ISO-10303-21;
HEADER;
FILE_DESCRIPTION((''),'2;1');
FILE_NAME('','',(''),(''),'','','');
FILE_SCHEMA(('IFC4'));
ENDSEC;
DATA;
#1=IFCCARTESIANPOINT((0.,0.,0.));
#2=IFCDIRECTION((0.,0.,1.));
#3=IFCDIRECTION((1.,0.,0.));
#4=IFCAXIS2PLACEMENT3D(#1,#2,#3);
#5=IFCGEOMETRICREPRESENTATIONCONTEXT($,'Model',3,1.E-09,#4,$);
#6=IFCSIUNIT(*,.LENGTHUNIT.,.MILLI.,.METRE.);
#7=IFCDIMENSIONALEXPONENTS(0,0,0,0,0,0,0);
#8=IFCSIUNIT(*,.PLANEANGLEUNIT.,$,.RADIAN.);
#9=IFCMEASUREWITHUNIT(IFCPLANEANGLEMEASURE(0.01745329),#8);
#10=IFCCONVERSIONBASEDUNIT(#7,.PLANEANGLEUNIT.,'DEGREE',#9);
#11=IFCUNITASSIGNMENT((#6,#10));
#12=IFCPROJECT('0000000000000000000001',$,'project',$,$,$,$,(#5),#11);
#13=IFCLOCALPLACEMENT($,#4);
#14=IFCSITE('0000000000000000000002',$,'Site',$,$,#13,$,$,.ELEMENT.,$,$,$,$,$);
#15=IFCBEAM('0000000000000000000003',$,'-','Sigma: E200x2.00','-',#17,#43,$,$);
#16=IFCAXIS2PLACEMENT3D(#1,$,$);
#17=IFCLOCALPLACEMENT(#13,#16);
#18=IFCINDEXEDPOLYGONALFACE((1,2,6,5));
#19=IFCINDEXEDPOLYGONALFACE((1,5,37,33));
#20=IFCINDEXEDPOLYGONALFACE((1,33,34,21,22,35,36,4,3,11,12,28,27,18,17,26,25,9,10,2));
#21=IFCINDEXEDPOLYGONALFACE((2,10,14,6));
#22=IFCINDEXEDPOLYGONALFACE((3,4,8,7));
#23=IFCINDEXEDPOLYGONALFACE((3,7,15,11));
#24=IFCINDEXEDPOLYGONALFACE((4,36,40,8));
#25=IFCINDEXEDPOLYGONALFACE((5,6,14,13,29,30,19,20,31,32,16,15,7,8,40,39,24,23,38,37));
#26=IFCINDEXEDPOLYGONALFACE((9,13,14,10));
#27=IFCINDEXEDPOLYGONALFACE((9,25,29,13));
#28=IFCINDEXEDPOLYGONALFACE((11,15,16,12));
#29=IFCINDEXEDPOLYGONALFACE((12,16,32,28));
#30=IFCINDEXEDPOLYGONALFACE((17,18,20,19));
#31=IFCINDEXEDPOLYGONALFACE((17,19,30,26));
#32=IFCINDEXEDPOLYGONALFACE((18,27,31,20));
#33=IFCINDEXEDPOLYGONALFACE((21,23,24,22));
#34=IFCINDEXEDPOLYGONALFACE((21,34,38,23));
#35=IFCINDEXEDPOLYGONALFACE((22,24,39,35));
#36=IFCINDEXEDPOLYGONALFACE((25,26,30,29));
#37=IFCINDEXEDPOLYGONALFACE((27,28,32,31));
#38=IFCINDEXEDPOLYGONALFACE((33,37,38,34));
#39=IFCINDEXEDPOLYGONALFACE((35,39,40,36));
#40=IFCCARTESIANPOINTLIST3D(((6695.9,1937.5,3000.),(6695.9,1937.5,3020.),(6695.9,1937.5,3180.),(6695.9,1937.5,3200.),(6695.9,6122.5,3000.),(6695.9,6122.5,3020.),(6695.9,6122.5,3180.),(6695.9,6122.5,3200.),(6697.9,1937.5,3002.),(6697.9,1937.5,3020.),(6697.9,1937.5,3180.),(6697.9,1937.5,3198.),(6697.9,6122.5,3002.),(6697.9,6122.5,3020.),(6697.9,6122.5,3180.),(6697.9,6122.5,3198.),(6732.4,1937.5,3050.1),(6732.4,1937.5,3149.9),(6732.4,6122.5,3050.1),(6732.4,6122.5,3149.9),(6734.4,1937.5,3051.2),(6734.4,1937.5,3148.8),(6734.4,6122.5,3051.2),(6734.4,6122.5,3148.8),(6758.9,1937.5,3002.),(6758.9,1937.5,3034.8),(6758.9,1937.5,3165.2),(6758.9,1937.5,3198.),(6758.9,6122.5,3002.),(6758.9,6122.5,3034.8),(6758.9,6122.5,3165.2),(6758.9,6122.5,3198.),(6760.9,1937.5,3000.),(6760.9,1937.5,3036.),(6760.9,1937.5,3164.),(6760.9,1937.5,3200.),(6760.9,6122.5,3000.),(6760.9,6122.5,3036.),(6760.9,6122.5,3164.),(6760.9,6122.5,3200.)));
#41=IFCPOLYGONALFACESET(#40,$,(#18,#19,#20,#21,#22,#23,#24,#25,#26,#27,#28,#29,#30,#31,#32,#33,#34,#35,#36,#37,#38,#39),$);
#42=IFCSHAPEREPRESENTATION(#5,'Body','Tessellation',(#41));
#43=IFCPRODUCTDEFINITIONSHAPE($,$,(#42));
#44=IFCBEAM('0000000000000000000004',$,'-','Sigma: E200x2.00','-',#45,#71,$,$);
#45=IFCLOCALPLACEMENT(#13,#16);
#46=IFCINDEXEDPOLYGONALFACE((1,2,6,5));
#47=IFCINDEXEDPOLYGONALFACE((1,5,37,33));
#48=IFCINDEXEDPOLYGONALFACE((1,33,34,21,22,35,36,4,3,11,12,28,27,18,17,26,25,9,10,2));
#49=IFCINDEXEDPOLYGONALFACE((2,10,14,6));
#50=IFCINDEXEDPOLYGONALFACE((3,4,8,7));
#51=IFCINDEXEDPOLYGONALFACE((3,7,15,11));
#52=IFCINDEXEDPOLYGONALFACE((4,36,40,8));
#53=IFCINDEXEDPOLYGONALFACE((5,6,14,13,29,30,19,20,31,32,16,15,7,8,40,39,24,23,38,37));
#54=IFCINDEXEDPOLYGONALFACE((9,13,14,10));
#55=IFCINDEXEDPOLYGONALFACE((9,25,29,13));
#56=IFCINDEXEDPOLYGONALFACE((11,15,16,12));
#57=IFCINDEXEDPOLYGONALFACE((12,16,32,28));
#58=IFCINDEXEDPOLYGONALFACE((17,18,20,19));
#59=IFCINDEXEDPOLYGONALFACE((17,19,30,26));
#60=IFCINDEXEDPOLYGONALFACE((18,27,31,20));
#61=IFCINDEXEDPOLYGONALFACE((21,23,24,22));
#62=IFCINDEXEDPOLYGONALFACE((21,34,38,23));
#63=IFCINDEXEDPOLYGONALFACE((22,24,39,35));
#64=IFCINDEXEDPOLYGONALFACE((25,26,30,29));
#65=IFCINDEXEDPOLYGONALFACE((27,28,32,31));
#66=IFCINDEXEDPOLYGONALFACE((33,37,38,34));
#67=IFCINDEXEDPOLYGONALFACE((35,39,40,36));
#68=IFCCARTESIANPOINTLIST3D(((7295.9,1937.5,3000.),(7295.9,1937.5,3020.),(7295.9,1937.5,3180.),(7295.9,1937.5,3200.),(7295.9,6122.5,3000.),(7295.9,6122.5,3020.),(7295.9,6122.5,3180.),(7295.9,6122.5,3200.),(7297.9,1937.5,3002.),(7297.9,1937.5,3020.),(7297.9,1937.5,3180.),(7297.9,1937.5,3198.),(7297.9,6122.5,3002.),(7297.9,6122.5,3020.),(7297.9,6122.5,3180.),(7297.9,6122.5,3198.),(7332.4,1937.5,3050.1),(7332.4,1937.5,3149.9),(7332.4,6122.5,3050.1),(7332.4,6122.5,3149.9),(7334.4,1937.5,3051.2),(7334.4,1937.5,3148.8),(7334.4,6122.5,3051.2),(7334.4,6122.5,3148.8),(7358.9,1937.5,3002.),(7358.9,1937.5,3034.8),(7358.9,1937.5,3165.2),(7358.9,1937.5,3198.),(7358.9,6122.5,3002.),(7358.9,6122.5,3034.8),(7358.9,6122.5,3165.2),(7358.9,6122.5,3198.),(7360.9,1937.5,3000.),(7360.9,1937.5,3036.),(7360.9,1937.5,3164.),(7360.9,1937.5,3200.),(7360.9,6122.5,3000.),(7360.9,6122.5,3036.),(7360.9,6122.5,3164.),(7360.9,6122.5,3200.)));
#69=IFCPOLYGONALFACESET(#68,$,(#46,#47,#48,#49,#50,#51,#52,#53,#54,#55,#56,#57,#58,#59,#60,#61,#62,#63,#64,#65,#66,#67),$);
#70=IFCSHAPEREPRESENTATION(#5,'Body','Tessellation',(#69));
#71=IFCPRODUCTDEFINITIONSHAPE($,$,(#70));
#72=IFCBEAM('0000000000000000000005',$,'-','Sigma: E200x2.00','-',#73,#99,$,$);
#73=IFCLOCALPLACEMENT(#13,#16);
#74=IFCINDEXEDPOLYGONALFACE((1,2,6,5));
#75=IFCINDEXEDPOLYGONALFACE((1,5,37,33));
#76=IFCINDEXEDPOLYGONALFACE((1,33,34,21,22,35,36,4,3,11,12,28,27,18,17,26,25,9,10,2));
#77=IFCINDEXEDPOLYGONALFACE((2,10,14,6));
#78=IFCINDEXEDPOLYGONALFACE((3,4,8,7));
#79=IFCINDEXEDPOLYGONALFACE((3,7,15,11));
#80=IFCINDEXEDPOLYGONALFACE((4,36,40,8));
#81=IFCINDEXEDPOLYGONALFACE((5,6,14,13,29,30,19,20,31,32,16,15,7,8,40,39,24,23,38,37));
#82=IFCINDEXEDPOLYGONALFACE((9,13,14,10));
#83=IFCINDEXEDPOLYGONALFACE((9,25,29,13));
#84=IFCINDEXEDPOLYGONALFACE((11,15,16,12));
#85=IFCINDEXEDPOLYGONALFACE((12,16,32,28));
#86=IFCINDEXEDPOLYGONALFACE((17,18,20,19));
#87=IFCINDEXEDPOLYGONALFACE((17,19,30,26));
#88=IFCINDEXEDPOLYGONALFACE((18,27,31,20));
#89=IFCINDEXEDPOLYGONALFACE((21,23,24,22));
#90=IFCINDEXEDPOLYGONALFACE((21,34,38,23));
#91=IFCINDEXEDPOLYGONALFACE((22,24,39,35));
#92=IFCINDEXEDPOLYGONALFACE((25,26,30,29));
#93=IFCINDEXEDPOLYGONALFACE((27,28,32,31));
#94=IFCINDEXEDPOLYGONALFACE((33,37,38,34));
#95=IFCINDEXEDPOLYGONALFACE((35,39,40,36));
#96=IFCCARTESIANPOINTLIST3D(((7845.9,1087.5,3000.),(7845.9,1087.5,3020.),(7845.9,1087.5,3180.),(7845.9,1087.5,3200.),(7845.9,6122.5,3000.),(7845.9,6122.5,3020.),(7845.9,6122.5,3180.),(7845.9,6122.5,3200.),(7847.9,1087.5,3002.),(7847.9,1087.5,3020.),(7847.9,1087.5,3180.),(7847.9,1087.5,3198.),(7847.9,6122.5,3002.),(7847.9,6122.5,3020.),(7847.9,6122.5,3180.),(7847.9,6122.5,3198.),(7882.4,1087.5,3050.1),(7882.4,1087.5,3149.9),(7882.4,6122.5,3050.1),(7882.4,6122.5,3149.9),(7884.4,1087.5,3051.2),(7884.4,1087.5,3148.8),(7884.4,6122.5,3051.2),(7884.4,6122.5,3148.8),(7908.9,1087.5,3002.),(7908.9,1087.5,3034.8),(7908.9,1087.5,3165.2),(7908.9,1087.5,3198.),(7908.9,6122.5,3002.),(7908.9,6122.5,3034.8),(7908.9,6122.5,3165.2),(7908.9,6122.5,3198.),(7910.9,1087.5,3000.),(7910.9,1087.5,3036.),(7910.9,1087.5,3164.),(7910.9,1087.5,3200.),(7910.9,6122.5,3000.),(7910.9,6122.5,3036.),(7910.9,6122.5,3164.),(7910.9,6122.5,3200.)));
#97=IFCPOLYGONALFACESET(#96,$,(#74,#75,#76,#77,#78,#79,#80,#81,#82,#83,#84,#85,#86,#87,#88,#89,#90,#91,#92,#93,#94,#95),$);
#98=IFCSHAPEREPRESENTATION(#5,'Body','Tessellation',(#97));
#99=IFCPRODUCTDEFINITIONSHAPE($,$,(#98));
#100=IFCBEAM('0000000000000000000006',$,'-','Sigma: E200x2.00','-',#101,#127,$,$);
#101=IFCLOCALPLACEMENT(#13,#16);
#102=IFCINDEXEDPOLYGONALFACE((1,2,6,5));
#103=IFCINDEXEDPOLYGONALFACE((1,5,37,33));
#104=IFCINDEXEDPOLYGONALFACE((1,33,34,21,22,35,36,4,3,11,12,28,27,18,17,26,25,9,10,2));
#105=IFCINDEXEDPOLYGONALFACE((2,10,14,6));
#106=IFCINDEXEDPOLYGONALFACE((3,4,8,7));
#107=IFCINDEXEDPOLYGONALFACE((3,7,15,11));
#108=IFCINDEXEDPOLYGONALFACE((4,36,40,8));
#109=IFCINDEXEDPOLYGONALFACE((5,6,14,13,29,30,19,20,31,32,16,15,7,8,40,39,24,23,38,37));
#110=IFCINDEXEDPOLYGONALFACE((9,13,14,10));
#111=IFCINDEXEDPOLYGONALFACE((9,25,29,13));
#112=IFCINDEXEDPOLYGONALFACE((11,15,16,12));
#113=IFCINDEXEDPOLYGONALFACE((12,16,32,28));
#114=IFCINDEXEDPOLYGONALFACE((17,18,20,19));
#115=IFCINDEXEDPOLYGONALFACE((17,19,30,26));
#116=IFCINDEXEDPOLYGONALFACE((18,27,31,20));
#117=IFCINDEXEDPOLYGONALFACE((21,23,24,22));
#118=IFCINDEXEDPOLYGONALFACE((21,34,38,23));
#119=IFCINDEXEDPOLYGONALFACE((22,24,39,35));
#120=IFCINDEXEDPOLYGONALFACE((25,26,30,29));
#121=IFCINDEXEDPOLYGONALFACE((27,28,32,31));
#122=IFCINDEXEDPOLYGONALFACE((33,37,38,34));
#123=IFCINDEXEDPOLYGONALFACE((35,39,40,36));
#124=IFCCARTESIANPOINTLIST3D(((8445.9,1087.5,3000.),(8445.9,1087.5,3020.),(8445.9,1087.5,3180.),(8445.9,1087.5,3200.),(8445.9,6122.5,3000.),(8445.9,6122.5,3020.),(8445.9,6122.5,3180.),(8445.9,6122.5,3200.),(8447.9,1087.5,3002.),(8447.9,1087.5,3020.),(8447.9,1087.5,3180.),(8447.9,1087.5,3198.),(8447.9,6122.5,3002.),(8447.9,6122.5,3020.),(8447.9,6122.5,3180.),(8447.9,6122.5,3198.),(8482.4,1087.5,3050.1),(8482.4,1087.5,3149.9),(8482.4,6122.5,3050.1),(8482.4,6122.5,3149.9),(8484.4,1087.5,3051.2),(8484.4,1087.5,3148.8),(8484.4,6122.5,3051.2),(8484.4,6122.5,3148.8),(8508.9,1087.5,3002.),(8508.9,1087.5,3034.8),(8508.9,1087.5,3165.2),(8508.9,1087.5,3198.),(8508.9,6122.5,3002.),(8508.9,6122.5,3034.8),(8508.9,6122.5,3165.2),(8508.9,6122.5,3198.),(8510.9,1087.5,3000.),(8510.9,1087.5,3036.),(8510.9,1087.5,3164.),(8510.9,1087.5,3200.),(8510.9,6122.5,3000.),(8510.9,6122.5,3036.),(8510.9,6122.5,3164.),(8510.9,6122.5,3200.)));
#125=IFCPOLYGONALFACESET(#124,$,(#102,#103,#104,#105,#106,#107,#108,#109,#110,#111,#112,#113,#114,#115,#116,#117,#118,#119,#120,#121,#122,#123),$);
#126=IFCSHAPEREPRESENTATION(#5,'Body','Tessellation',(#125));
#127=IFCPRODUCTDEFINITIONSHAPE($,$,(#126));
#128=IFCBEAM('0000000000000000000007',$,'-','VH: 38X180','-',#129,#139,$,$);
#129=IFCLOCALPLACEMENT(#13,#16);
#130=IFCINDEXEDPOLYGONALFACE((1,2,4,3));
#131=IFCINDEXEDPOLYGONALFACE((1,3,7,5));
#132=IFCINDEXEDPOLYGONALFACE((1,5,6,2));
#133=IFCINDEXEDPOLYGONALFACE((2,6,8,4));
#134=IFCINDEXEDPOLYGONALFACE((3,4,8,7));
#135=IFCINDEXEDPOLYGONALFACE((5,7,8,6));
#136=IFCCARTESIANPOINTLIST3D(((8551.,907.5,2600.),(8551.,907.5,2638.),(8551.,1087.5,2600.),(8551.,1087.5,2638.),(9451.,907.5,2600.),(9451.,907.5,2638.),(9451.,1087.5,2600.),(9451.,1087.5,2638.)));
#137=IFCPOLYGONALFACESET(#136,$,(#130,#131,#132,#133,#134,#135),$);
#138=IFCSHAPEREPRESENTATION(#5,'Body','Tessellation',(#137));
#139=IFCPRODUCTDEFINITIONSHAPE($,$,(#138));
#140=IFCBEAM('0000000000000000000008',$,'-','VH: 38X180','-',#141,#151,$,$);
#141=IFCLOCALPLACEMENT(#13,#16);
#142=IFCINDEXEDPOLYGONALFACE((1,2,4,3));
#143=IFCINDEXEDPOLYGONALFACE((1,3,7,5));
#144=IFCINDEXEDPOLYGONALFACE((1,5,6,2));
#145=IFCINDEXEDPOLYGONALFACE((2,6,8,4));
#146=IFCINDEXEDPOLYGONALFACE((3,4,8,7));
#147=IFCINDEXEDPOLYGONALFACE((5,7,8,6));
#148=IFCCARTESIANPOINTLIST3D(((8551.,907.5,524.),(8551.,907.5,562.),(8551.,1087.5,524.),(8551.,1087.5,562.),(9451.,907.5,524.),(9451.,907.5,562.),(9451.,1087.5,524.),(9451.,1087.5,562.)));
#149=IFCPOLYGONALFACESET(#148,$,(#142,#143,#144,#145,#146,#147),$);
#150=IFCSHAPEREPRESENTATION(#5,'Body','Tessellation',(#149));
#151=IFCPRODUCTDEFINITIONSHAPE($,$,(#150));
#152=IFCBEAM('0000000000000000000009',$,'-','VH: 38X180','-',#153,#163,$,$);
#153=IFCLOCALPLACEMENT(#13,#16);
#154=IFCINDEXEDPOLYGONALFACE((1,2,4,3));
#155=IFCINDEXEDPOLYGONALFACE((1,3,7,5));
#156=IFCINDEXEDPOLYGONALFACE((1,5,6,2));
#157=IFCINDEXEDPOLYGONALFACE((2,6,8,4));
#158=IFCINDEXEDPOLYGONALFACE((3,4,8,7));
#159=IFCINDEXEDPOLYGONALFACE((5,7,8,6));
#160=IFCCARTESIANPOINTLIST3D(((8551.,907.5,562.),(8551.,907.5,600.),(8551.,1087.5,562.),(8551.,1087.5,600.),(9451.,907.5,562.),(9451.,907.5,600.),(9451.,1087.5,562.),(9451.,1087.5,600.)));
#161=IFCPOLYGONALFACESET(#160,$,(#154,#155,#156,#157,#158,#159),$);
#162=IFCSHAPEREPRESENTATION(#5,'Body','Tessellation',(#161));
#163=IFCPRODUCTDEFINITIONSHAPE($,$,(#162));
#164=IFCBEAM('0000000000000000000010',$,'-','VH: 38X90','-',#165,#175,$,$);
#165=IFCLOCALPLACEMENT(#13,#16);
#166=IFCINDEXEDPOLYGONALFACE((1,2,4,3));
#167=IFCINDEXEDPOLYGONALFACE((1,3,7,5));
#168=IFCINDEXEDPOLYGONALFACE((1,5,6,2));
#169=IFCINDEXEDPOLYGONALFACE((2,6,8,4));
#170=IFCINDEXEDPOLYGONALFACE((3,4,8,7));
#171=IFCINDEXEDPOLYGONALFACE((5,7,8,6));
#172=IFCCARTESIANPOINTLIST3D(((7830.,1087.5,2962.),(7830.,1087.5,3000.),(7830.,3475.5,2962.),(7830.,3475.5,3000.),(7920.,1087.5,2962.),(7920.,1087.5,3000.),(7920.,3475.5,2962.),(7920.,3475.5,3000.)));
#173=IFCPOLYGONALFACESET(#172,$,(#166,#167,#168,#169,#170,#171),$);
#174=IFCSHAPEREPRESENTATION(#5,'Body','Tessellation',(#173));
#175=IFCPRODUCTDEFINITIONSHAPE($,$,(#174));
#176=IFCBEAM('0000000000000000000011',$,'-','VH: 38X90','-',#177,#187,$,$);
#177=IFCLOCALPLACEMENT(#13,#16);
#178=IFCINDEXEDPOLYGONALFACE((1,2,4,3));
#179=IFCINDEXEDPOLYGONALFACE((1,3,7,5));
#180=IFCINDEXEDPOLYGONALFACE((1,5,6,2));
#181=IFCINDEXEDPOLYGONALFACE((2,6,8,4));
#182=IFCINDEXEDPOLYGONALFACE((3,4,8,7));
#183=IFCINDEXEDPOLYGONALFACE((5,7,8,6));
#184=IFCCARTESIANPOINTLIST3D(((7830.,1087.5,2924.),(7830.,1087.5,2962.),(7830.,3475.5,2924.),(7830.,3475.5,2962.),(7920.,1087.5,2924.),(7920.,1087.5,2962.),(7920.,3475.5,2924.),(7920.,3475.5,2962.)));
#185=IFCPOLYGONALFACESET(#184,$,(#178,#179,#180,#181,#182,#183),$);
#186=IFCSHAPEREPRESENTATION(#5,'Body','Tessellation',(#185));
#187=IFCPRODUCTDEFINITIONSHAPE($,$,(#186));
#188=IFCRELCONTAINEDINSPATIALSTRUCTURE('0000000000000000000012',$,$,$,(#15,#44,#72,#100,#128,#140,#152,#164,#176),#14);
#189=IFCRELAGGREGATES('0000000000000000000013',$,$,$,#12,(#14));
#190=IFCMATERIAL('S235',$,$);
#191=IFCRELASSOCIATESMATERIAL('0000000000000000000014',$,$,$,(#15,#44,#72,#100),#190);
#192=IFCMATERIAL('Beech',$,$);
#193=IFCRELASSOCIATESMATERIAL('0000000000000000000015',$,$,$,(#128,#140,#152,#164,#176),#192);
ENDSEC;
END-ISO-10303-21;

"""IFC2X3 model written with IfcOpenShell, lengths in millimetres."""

from ifc_helpers import new_model, entity, si_unit, converted_unit, frame, origin, origin_with_axes, origin_2d, place, context, project, spatial, polyline, rectangle, outline, extrude, material, element, save


model = new_model("IFC2X3")

# Units and contexts
model_context = context("Model", 3, precision=1e-09, world=origin_with_axes())
ifc_project = project(units=[si_unit("LENGTHUNIT", "METRE", prefix="MILLI"), converted_unit("PLANEANGLEUNIT", "DEGREE", entity("IfcPlaneAngleMeasure", 0.01745329), si_unit("PLANEANGLEUNIT", "RADIAN"), dimensions=[0, 0, 0, 0, 0, 0, 0])], contexts=[model_context])

# Site
site_placement = place(None, origin_with_axes())
site = spatial("IfcSite", under=ifc_project, at=site_placement, Name="Site", CompositionType="ELEMENT")

# Shared definitions
ifc_material_1 = material(Name="Beech")

# Beams
ifc_material_2 = material(Name="S235")
for number, where, z_axis, x_axis, name in (
    (1, (6735.0, 1937.5, 3100.0), (0.0, 1.0, 0.0), (-1.0, 0.0, 0.0), "-"),
    (2, (7335.0, 1937.5, 3100.0), (0.0, 1.0, 0.0), (-1.0, 0.0, 0.0), "-"),
):
    element("IfcBeam", number, at=place(None, frame(where, z_axis=z_axis, x_axis=x_axis)), inside=site, material=ifc_material_2, Name=name, Description="Sigma: E200x2.00", ObjectType="-", context=model_context, shape_type="SweptSolid", body=[
        extrude(outline(polyline([(39.1, -100.0), (39.1, -80.0), (37.1, -80.0), (37.1, -98.0), (-23.9, -98.0), (-23.9, -65.2), (2.6, -49.9), (2.6, 49.9), (-23.9, 65.2), (-23.9, 98.0), (37.1, 98.0), (37.1, 80.0), (39.1, 80.0), (39.1, 100.0), (-25.9, 100.0), (-25.9, 64.0), (0.6, 48.8), (0.6, -48.8), (-25.9, -64.0), (-25.9, -100.0), (39.1, -100.0)])), origin(), (0.0, 0.0, 1.0), 4185.0),
    ])
for number, where, z_axis, x_axis, name in (
    (3, (7885.0, 1087.5, 3100.0), (0.0, 1.0, 0.0), (-1.0, 0.0, 0.0), "-"),
    (4, (8485.0, 1087.5, 3100.0), (0.0, 1.0, 0.0), (-1.0, 0.0, 0.0), "-"),
):
    element("IfcBeam", number, at=place(None, frame(where, z_axis=z_axis, x_axis=x_axis)), inside=site, material=ifc_material_2, Name=name, Description="Sigma: E200x2.00", ObjectType="-", context=model_context, shape_type="SweptSolid", body=[
        extrude(outline(polyline([(39.1, -100.0), (39.1, -80.0), (37.1, -80.0), (37.1, -98.0), (-23.9, -98.0), (-23.9, -65.2), (2.6, -49.9), (2.6, 49.9), (-23.9, 65.2), (-23.9, 98.0), (37.1, 98.0), (37.1, 80.0), (39.1, 80.0), (39.1, 100.0), (-25.9, 100.0), (-25.9, 64.0), (0.6, 48.8), (0.6, -48.8), (-25.9, -64.0), (-25.9, -100.0), (39.1, -100.0)])), origin(), (0.0, 0.0, 1.0), 5035.0),
    ])
for number, where, z_axis, x_axis, name in (
    (5, (8551.0, 997.5, 2619.0), (-1.0, 0.0, 0.0), (0.0, 0.0, -1.0), "-"),
    (6, (8551.0, 997.5, 543.0), (-1.0, 0.0, 0.0), (0.0, 0.0, -1.0), "-"),
    (7, (8551.0, 997.5, 581.0), (-1.0, 0.0, 0.0), (0.0, 0.0, -1.0), "-"),
):
    element("IfcBeam", number, at=place(None, frame(where, z_axis=z_axis, x_axis=x_axis)), inside=site, material=ifc_material_1, Name=name, Description="VH: 38X180", ObjectType="-", context=model_context, shape_type="SweptSolid", body=[
        extrude(rectangle(XDim=38.0, YDim=180.0, at=origin_2d()), origin(), (0.0, 0.0, -1.0), 900.0),
    ])
for number, where, z_axis, x_axis, name in (
    (8, (7875.0, 1087.5, 2981.0), (0.0, -1.0, 0.0), (0.0, 0.0, -1.0), "-"),
    (9, (7875.0, 1087.5, 2943.0), (0.0, -1.0, 0.0), (0.0, 0.0, -1.0), "-"),
):
    element("IfcBeam", number, at=place(None, frame(where, z_axis=z_axis, x_axis=x_axis)), inside=site, material=ifc_material_1, Name=name, Description="VH: 38X90", ObjectType="-", context=model_context, shape_type="SweptSolid", body=[
        extrude(rectangle(XDim=38.0, YDim=90.0, at=origin_2d()), origin(), (0.0, 0.0, -1.0), 2388.0),
    ])

save(model, "model.ifc")
